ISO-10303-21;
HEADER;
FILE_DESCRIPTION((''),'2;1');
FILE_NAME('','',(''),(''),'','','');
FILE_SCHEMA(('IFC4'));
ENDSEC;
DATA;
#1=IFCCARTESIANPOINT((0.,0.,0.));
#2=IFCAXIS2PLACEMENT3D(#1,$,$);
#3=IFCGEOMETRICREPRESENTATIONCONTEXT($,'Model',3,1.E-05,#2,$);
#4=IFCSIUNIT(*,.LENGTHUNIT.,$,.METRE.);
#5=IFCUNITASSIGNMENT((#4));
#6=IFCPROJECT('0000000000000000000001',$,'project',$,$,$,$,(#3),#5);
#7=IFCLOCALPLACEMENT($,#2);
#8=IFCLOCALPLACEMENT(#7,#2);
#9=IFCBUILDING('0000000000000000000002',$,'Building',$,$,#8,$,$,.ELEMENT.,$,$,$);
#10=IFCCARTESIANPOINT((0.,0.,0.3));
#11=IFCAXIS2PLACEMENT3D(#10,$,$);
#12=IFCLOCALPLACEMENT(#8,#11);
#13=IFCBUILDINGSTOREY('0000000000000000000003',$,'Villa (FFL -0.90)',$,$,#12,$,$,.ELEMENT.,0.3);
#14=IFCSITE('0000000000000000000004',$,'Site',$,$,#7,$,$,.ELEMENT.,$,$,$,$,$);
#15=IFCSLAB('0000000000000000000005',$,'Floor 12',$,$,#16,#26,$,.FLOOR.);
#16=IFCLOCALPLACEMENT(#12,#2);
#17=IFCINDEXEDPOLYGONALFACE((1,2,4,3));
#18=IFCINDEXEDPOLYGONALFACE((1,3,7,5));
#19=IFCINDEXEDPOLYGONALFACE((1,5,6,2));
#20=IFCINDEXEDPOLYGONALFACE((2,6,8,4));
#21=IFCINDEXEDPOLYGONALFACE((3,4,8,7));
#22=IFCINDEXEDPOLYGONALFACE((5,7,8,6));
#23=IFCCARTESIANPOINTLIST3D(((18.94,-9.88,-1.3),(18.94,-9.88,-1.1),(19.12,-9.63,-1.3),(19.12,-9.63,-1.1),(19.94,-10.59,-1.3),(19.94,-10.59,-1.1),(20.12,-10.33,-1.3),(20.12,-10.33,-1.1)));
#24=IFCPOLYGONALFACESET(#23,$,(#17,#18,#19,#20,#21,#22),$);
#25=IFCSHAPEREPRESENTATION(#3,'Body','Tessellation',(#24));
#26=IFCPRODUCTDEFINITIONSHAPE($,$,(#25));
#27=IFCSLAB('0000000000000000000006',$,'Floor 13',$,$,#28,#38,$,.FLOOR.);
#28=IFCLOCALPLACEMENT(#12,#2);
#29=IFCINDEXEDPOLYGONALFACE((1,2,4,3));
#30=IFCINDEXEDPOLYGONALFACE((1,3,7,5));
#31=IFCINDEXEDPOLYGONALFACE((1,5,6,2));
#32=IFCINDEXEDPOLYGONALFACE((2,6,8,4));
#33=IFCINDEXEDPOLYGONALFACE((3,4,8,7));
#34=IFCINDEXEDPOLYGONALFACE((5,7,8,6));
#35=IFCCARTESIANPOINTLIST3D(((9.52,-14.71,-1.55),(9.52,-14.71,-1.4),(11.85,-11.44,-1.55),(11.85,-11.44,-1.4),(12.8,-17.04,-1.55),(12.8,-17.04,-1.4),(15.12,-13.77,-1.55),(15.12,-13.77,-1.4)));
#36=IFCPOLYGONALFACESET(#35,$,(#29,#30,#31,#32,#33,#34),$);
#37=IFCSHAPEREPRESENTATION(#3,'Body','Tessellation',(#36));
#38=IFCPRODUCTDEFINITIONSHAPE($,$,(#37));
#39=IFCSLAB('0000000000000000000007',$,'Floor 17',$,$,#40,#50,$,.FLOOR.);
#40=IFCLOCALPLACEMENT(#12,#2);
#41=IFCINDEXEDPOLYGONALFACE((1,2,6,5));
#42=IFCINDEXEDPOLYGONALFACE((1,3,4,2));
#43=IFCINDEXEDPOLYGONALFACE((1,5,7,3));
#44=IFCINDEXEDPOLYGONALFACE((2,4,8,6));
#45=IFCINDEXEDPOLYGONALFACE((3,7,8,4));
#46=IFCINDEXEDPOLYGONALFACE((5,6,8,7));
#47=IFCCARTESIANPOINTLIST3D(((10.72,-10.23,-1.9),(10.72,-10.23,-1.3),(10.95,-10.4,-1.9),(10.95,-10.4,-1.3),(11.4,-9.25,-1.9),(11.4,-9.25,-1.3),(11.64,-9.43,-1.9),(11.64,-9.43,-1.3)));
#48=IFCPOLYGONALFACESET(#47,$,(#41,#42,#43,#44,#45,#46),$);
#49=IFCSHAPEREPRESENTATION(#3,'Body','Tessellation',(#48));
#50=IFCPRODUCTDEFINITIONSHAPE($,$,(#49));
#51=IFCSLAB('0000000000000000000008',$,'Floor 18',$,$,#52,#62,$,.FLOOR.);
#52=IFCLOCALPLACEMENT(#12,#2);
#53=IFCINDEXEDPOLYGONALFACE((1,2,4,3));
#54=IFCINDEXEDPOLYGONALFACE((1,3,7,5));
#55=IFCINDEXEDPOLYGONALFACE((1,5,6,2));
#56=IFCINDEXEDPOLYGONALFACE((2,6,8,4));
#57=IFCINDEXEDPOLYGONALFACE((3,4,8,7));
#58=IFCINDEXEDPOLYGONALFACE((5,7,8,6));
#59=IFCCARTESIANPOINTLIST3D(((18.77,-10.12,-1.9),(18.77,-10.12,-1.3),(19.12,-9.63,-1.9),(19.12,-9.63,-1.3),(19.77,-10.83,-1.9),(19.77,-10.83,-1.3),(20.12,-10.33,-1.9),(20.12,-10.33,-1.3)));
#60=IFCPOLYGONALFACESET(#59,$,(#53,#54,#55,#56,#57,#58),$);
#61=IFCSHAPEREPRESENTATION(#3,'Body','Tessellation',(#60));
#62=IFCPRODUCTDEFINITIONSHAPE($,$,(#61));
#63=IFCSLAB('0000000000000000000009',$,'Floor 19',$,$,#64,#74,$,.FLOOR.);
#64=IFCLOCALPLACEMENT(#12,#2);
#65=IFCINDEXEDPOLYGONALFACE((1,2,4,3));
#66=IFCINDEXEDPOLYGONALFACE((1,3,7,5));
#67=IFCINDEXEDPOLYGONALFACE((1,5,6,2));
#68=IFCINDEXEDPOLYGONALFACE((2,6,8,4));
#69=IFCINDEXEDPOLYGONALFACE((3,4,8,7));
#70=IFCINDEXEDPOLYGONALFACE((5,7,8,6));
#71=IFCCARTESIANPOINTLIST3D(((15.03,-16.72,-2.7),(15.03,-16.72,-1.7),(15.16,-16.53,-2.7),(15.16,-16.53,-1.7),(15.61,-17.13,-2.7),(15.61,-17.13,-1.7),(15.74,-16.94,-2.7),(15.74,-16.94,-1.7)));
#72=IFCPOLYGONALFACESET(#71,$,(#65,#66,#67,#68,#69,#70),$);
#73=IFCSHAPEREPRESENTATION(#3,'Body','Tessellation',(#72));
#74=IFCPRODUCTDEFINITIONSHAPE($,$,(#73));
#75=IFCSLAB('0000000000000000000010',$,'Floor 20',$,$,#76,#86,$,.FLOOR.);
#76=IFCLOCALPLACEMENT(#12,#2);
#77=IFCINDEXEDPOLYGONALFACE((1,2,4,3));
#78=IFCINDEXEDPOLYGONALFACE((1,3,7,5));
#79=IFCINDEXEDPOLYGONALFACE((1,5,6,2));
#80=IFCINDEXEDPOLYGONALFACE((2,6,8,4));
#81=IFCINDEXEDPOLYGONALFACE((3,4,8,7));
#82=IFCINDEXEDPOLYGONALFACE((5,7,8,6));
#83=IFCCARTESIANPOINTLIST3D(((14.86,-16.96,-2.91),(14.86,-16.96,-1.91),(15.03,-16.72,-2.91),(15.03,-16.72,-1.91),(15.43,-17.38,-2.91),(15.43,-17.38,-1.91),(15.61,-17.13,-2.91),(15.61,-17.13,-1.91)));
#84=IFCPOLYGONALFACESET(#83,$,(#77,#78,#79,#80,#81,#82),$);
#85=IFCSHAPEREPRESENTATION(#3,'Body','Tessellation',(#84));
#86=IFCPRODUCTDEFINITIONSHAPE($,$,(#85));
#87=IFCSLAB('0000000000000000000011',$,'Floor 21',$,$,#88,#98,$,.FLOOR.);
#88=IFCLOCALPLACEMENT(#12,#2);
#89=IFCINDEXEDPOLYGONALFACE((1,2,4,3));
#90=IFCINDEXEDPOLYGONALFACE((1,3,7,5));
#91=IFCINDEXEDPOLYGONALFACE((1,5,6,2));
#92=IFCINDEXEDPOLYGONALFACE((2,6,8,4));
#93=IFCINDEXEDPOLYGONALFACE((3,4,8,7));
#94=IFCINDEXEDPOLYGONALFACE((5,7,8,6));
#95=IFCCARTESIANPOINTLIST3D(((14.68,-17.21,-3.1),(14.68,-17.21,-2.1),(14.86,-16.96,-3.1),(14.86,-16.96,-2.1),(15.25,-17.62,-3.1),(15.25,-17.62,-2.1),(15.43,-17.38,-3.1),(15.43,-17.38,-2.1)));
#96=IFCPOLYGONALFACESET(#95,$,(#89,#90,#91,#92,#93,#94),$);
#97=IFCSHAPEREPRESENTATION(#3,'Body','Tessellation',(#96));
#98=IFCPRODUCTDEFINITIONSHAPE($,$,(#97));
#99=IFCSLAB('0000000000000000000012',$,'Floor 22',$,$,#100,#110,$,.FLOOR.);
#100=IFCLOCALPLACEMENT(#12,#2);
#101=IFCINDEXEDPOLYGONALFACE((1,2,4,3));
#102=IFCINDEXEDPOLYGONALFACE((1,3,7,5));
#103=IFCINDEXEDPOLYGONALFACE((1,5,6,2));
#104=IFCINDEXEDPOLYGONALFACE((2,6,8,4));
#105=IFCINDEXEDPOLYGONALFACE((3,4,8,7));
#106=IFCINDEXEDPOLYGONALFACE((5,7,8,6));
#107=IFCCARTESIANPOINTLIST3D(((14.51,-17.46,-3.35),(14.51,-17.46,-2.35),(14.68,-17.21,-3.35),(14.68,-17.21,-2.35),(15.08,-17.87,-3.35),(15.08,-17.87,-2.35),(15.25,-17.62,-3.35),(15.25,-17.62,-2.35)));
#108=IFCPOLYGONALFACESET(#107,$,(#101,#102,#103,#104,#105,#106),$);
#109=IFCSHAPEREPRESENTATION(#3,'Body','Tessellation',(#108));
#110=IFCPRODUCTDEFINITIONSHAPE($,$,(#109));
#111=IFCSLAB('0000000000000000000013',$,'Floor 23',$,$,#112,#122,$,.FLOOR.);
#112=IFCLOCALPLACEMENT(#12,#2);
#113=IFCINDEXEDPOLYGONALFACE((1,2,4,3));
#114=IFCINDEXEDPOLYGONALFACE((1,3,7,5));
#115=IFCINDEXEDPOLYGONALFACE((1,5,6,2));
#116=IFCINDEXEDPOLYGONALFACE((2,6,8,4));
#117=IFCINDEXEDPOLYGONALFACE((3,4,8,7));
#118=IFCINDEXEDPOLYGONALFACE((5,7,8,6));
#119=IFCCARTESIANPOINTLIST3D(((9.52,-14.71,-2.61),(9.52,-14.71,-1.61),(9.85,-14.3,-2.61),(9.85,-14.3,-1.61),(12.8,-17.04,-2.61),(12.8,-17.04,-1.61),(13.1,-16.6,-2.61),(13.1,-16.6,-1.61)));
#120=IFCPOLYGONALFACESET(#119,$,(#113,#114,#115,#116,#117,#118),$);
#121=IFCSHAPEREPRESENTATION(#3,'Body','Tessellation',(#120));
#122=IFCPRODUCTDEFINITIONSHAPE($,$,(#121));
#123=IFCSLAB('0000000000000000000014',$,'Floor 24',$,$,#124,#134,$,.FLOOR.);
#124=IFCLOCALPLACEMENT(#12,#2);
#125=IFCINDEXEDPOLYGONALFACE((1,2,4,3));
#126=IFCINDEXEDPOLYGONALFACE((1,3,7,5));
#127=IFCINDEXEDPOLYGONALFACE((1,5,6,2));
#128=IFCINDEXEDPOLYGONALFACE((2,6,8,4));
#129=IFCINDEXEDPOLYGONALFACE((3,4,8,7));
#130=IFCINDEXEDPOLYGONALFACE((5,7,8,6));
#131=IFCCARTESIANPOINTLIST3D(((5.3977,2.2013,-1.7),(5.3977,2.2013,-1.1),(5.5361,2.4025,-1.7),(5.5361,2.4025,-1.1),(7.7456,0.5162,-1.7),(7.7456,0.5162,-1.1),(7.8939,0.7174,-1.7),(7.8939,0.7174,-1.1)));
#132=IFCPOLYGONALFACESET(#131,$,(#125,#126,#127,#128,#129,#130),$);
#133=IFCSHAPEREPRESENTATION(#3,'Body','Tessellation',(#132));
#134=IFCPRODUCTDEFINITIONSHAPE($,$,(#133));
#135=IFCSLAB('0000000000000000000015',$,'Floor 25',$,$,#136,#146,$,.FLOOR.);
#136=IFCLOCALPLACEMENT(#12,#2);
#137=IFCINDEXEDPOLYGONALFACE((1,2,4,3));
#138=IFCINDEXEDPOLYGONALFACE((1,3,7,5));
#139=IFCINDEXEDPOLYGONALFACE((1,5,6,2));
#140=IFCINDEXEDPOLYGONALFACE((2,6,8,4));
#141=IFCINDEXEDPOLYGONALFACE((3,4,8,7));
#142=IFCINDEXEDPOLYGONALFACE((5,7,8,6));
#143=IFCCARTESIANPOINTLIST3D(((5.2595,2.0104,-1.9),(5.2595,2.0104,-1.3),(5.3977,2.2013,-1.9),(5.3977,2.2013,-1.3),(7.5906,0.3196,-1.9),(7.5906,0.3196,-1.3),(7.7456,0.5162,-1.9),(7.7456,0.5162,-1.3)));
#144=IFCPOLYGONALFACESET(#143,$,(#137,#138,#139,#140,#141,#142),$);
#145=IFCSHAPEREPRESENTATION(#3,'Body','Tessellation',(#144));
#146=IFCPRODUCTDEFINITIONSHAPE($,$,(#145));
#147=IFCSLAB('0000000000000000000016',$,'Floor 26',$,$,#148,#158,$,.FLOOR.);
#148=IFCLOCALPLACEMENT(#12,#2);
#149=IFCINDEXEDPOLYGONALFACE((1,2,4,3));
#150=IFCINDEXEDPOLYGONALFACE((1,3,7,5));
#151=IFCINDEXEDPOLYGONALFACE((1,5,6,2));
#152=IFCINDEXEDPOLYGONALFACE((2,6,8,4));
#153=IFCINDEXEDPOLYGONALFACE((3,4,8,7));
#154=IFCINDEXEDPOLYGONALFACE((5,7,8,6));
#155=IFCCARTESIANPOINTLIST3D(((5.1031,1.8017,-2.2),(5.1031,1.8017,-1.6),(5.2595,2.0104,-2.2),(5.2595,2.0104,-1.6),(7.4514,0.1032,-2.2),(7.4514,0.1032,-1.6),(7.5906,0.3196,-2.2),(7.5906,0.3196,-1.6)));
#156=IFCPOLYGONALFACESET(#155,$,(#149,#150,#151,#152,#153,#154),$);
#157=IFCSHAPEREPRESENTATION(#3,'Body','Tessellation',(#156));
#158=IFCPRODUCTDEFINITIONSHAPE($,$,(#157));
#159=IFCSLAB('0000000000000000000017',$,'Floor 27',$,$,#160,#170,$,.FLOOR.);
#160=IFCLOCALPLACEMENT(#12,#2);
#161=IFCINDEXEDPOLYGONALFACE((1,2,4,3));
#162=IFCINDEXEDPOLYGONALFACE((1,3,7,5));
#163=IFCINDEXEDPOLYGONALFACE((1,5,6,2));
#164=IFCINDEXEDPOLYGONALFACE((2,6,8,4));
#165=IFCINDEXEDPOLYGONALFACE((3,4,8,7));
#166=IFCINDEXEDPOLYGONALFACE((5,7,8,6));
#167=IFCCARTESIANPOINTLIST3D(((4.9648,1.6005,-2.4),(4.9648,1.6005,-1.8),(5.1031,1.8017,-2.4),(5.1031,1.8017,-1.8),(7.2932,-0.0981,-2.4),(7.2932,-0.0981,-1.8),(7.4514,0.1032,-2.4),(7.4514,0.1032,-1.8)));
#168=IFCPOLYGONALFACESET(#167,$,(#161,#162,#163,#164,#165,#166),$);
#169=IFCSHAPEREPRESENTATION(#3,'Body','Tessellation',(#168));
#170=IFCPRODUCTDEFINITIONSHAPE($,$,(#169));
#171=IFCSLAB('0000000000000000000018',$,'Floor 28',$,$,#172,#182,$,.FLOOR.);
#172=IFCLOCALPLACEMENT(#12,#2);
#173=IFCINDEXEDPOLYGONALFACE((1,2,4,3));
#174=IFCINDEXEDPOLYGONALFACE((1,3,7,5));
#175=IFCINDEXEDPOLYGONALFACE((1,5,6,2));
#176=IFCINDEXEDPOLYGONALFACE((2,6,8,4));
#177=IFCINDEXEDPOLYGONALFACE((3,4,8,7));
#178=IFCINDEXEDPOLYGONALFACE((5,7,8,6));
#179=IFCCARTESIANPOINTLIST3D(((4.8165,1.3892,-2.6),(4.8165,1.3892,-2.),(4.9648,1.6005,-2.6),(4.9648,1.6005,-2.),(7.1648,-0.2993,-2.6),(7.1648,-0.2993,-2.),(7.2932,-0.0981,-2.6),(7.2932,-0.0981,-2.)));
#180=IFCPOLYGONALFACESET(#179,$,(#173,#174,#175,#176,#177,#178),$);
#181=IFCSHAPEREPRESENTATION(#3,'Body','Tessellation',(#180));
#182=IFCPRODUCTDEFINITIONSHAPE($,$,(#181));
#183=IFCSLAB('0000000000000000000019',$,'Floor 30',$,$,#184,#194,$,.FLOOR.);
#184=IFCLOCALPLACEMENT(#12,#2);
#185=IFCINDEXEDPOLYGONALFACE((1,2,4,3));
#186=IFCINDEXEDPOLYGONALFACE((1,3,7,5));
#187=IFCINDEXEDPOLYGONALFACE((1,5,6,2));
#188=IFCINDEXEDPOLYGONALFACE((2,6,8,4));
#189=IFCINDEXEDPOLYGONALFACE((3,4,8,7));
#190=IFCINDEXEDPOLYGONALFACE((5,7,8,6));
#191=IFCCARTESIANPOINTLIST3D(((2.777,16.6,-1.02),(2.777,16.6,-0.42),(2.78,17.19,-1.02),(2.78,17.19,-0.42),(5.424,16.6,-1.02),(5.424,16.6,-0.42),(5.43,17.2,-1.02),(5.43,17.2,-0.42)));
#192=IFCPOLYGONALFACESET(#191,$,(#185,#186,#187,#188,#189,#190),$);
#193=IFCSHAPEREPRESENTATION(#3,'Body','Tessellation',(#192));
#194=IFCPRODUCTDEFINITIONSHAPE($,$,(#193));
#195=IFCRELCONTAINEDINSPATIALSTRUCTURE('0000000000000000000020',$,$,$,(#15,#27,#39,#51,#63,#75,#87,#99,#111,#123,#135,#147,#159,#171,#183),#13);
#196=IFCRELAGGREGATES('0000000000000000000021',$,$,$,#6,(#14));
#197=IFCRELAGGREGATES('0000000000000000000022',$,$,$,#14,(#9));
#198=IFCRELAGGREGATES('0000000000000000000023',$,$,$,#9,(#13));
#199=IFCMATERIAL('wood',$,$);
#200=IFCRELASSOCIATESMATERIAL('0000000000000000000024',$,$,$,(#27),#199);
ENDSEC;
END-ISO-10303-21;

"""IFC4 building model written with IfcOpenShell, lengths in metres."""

from ifc_helpers import new_model, si_unit, frame, origin, place, context, project, spatial, polyline, outline, extrude, material, element, save


model = new_model("IFC4")

# Units and contexts
model_context = context("Model", 3, precision=1e-05, world=origin())
ifc_project = project(units=[si_unit("LENGTHUNIT", "METRE")], contexts=[model_context])

# Site, building, storey
site_placement = place(None, origin())
site = spatial("IfcSite", under=ifc_project, at=site_placement, Name="Site", CompositionType="ELEMENT")
building_placement = place(site_placement, origin())
building = spatial("IfcBuilding", under=site, at=building_placement, Name="Building", CompositionType="ELEMENT")
storey_placement = place(building_placement, frame((0.0, 0.0, 0.3)))
storey = spatial("IfcBuildingStorey", under=building, at=storey_placement, Name="Villa (FFL -0.90)", CompositionType="ELEMENT", Elevation=0.3)

# Slabs
ifc_material_1 = material(Name="wood")
slab_1_placement = place(storey_placement, frame((0.0, 0.0, -1.3), z_axis=(0.0, 0.0, 1.0), x_axis=(1.0, 0.0, 0.0)))
element("IfcSlab", 1, at=slab_1_placement, inside=storey, Name="Floor 12", PredefinedType="FLOOR", context=model_context, shape_type="SweptSolid", body=[
    extrude(outline(polyline([(18.94, -9.88), (19.94, -10.59), (20.12, -10.33), (19.12, -9.63), (18.94, -9.88)])), origin(), (0.0, 0.0, 1.0), 0.2),
])
slab_2_placement = place(storey_placement, frame((0.0, 0.0, -1.55), z_axis=(0.0, 0.0, 1.0), x_axis=(1.0, 0.0, 0.0)))
element("IfcSlab", 2, at=slab_2_placement, inside=storey, material=ifc_material_1, Name="Floor 13", PredefinedType="FLOOR", context=model_context, shape_type="SweptSolid", body=[
    extrude(outline(polyline([(11.85, -11.44), (15.12, -13.77), (12.8, -17.04), (9.52, -14.71), (11.85, -11.44)])), origin(), (0.0, 0.0, 1.0), 0.15),
])
slab_3_placement = place(storey_placement, frame((0.0, 0.0, -1.9), z_axis=(0.0, 0.0, 1.0), x_axis=(1.0, 0.0, 0.0)))
element("IfcSlab", 3, at=slab_3_placement, inside=storey, Name="Floor 17", PredefinedType="FLOOR", context=model_context, shape_type="SweptSolid", body=[
    extrude(outline(polyline([(10.72, -10.23), (10.95, -10.4), (11.64, -9.43), (11.4, -9.25), (10.72, -10.23)])), origin(), (0.0, 0.0, 1.0), 0.6),
])
slab_4_placement = place(storey_placement, frame((0.0, 0.0, -1.9), z_axis=(0.0, 0.0, 1.0), x_axis=(1.0, 0.0, 0.0)))
element("IfcSlab", 4, at=slab_4_placement, inside=storey, Name="Floor 18", PredefinedType="FLOOR", context=model_context, shape_type="SweptSolid", body=[
    extrude(outline(polyline([(18.77, -10.12), (19.77, -10.83), (20.12, -10.33), (19.12, -9.63), (18.77, -10.12)])), origin(), (0.0, 0.0, 1.0), 0.6),
])
slab_5_placement = place(storey_placement, frame((0.0, 0.0, -2.7), z_axis=(0.0, 0.0, 1.0), x_axis=(1.0, 0.0, 0.0)))
element("IfcSlab", 5, at=slab_5_placement, inside=storey, Name="Floor 19", PredefinedType="FLOOR", context=model_context, shape_type="SweptSolid", body=[
    extrude(outline(polyline([(15.03, -16.72), (15.61, -17.13), (15.74, -16.94), (15.16, -16.53), (15.03, -16.72)])), origin(), (0.0, 0.0, 1.0), 1.0),
])
slab_6_placement = place(storey_placement, frame((0.0, 0.0, -2.91), z_axis=(0.0, 0.0, 1.0), x_axis=(1.0, 0.0, 0.0)))
element("IfcSlab", 6, at=slab_6_placement, inside=storey, Name="Floor 20", PredefinedType="FLOOR", context=model_context, shape_type="SweptSolid", body=[
    extrude(outline(polyline([(14.86, -16.96), (15.43, -17.38), (15.61, -17.13), (15.03, -16.72), (14.86, -16.96)])), origin(), (0.0, 0.0, 1.0), 1.0),
])
slab_7_placement = place(storey_placement, frame((0.0, 0.0, -3.1), z_axis=(0.0, 0.0, 1.0), x_axis=(1.0, 0.0, 0.0)))
element("IfcSlab", 7, at=slab_7_placement, inside=storey, Name="Floor 21", PredefinedType="FLOOR", context=model_context, shape_type="SweptSolid", body=[
    extrude(outline(polyline([(14.68, -17.21), (15.25, -17.62), (15.43, -17.38), (14.86, -16.96), (14.68, -17.21)])), origin(), (0.0, 0.0, 1.0), 1.0),
])
slab_8_placement = place(storey_placement, frame((0.0, 0.0, -3.35), z_axis=(0.0, 0.0, 1.0), x_axis=(1.0, 0.0, 0.0)))
element("IfcSlab", 8, at=slab_8_placement, inside=storey, Name="Floor 22", PredefinedType="FLOOR", context=model_context, shape_type="SweptSolid", body=[
    extrude(outline(polyline([(14.51, -17.46), (15.08, -17.87), (15.25, -17.62), (14.68, -17.21), (14.51, -17.46)])), origin(), (0.0, 0.0, 1.0), 1.0),
])
slab_9_placement = place(storey_placement, frame((0.0, 0.0, -2.61), z_axis=(0.0, 0.0, 1.0), x_axis=(1.0, 0.0, 0.0)))
element("IfcSlab", 9, at=slab_9_placement, inside=storey, Name="Floor 23", PredefinedType="FLOOR", context=model_context, shape_type="SweptSolid", body=[
    extrude(outline(polyline([(9.52, -14.71), (12.8, -17.04), (13.1, -16.6), (9.85, -14.3), (9.52, -14.71)])), origin(), (0.0, 0.0, 1.0), 1.0),
])
slab_10_placement = place(storey_placement, frame((0.0, 0.0, -1.7), z_axis=(0.0, 0.0, 1.0), x_axis=(1.0, 0.0, 0.0)))
element("IfcSlab", 10, at=slab_10_placement, inside=storey, Name="Floor 24", PredefinedType="FLOOR", context=model_context, shape_type="SweptSolid", body=[
    extrude(outline(polyline([(5.3977, 2.2013), (7.7456, 0.5162), (7.8939, 0.7174), (5.5361, 2.4025), (5.3977, 2.2013)])), origin(), (0.0, 0.0, 1.0), 0.6),
])
slab_11_placement = place(storey_placement, frame((0.0, 0.0, -1.9), z_axis=(0.0, 0.0, 1.0), x_axis=(1.0, 0.0, 0.0)))
element("IfcSlab", 11, at=slab_11_placement, inside=storey, Name="Floor 25", PredefinedType="FLOOR", context=model_context, shape_type="SweptSolid", body=[
    extrude(outline(polyline([(5.2595, 2.0104), (7.5906, 0.3196), (7.7456, 0.5162), (5.3977, 2.2013), (5.2595, 2.0104)])), origin(), (0.0, 0.0, 1.0), 0.6),
])
slab_12_placement = place(storey_placement, frame((0.0, 0.0, -2.2), z_axis=(0.0, 0.0, 1.0), x_axis=(1.0, 0.0, 0.0)))
element("IfcSlab", 12, at=slab_12_placement, inside=storey, Name="Floor 26", PredefinedType="FLOOR", context=model_context, shape_type="SweptSolid", body=[
    extrude(outline(polyline([(5.1031, 1.8017), (7.4514, 0.1032), (7.5906, 0.3196), (5.2595, 2.0104), (5.1031, 1.8017)])), origin(), (0.0, 0.0, 1.0), 0.6),
])
slab_13_placement = place(storey_placement, frame((0.0, 0.0, -2.4), z_axis=(0.0, 0.0, 1.0), x_axis=(1.0, 0.0, 0.0)))
element("IfcSlab", 13, at=slab_13_placement, inside=storey, Name="Floor 27", PredefinedType="FLOOR", context=model_context, shape_type="SweptSolid", body=[
    extrude(outline(polyline([(4.9648, 1.6005), (7.2932, -0.0981), (7.4514, 0.1032), (5.1031, 1.8017), (4.9648, 1.6005)])), origin(), (0.0, 0.0, 1.0), 0.6),
])
slab_14_placement = place(storey_placement, frame((0.0, 0.0, -2.6), z_axis=(0.0, 0.0, 1.0), x_axis=(1.0, 0.0, 0.0)))
element("IfcSlab", 14, at=slab_14_placement, inside=storey, Name="Floor 28", PredefinedType="FLOOR", context=model_context, shape_type="SweptSolid", body=[
    extrude(outline(polyline([(4.8165, 1.3892), (7.1648, -0.2993), (7.2932, -0.0981), (4.9648, 1.6005), (4.8165, 1.3892)])), origin(), (0.0, 0.0, 1.0), 0.6),
])
slab_15_placement = place(storey_placement, frame((0.0, 0.0, -1.02), z_axis=(0.0, 0.0, 1.0), x_axis=(1.0, 0.0, 0.0)))
element("IfcSlab", 15, at=slab_15_placement, inside=storey, Name="Floor 30", PredefinedType="FLOOR", context=model_context, shape_type="SweptSolid", body=[
    extrude(outline(polyline([(5.43, 17.2), (5.424, 16.6), (2.777, 16.6), (2.78, 17.19), (5.43, 17.2)])), origin(), (0.0, 0.0, 1.0), 0.6),
])

save(model, "model.ifc")
